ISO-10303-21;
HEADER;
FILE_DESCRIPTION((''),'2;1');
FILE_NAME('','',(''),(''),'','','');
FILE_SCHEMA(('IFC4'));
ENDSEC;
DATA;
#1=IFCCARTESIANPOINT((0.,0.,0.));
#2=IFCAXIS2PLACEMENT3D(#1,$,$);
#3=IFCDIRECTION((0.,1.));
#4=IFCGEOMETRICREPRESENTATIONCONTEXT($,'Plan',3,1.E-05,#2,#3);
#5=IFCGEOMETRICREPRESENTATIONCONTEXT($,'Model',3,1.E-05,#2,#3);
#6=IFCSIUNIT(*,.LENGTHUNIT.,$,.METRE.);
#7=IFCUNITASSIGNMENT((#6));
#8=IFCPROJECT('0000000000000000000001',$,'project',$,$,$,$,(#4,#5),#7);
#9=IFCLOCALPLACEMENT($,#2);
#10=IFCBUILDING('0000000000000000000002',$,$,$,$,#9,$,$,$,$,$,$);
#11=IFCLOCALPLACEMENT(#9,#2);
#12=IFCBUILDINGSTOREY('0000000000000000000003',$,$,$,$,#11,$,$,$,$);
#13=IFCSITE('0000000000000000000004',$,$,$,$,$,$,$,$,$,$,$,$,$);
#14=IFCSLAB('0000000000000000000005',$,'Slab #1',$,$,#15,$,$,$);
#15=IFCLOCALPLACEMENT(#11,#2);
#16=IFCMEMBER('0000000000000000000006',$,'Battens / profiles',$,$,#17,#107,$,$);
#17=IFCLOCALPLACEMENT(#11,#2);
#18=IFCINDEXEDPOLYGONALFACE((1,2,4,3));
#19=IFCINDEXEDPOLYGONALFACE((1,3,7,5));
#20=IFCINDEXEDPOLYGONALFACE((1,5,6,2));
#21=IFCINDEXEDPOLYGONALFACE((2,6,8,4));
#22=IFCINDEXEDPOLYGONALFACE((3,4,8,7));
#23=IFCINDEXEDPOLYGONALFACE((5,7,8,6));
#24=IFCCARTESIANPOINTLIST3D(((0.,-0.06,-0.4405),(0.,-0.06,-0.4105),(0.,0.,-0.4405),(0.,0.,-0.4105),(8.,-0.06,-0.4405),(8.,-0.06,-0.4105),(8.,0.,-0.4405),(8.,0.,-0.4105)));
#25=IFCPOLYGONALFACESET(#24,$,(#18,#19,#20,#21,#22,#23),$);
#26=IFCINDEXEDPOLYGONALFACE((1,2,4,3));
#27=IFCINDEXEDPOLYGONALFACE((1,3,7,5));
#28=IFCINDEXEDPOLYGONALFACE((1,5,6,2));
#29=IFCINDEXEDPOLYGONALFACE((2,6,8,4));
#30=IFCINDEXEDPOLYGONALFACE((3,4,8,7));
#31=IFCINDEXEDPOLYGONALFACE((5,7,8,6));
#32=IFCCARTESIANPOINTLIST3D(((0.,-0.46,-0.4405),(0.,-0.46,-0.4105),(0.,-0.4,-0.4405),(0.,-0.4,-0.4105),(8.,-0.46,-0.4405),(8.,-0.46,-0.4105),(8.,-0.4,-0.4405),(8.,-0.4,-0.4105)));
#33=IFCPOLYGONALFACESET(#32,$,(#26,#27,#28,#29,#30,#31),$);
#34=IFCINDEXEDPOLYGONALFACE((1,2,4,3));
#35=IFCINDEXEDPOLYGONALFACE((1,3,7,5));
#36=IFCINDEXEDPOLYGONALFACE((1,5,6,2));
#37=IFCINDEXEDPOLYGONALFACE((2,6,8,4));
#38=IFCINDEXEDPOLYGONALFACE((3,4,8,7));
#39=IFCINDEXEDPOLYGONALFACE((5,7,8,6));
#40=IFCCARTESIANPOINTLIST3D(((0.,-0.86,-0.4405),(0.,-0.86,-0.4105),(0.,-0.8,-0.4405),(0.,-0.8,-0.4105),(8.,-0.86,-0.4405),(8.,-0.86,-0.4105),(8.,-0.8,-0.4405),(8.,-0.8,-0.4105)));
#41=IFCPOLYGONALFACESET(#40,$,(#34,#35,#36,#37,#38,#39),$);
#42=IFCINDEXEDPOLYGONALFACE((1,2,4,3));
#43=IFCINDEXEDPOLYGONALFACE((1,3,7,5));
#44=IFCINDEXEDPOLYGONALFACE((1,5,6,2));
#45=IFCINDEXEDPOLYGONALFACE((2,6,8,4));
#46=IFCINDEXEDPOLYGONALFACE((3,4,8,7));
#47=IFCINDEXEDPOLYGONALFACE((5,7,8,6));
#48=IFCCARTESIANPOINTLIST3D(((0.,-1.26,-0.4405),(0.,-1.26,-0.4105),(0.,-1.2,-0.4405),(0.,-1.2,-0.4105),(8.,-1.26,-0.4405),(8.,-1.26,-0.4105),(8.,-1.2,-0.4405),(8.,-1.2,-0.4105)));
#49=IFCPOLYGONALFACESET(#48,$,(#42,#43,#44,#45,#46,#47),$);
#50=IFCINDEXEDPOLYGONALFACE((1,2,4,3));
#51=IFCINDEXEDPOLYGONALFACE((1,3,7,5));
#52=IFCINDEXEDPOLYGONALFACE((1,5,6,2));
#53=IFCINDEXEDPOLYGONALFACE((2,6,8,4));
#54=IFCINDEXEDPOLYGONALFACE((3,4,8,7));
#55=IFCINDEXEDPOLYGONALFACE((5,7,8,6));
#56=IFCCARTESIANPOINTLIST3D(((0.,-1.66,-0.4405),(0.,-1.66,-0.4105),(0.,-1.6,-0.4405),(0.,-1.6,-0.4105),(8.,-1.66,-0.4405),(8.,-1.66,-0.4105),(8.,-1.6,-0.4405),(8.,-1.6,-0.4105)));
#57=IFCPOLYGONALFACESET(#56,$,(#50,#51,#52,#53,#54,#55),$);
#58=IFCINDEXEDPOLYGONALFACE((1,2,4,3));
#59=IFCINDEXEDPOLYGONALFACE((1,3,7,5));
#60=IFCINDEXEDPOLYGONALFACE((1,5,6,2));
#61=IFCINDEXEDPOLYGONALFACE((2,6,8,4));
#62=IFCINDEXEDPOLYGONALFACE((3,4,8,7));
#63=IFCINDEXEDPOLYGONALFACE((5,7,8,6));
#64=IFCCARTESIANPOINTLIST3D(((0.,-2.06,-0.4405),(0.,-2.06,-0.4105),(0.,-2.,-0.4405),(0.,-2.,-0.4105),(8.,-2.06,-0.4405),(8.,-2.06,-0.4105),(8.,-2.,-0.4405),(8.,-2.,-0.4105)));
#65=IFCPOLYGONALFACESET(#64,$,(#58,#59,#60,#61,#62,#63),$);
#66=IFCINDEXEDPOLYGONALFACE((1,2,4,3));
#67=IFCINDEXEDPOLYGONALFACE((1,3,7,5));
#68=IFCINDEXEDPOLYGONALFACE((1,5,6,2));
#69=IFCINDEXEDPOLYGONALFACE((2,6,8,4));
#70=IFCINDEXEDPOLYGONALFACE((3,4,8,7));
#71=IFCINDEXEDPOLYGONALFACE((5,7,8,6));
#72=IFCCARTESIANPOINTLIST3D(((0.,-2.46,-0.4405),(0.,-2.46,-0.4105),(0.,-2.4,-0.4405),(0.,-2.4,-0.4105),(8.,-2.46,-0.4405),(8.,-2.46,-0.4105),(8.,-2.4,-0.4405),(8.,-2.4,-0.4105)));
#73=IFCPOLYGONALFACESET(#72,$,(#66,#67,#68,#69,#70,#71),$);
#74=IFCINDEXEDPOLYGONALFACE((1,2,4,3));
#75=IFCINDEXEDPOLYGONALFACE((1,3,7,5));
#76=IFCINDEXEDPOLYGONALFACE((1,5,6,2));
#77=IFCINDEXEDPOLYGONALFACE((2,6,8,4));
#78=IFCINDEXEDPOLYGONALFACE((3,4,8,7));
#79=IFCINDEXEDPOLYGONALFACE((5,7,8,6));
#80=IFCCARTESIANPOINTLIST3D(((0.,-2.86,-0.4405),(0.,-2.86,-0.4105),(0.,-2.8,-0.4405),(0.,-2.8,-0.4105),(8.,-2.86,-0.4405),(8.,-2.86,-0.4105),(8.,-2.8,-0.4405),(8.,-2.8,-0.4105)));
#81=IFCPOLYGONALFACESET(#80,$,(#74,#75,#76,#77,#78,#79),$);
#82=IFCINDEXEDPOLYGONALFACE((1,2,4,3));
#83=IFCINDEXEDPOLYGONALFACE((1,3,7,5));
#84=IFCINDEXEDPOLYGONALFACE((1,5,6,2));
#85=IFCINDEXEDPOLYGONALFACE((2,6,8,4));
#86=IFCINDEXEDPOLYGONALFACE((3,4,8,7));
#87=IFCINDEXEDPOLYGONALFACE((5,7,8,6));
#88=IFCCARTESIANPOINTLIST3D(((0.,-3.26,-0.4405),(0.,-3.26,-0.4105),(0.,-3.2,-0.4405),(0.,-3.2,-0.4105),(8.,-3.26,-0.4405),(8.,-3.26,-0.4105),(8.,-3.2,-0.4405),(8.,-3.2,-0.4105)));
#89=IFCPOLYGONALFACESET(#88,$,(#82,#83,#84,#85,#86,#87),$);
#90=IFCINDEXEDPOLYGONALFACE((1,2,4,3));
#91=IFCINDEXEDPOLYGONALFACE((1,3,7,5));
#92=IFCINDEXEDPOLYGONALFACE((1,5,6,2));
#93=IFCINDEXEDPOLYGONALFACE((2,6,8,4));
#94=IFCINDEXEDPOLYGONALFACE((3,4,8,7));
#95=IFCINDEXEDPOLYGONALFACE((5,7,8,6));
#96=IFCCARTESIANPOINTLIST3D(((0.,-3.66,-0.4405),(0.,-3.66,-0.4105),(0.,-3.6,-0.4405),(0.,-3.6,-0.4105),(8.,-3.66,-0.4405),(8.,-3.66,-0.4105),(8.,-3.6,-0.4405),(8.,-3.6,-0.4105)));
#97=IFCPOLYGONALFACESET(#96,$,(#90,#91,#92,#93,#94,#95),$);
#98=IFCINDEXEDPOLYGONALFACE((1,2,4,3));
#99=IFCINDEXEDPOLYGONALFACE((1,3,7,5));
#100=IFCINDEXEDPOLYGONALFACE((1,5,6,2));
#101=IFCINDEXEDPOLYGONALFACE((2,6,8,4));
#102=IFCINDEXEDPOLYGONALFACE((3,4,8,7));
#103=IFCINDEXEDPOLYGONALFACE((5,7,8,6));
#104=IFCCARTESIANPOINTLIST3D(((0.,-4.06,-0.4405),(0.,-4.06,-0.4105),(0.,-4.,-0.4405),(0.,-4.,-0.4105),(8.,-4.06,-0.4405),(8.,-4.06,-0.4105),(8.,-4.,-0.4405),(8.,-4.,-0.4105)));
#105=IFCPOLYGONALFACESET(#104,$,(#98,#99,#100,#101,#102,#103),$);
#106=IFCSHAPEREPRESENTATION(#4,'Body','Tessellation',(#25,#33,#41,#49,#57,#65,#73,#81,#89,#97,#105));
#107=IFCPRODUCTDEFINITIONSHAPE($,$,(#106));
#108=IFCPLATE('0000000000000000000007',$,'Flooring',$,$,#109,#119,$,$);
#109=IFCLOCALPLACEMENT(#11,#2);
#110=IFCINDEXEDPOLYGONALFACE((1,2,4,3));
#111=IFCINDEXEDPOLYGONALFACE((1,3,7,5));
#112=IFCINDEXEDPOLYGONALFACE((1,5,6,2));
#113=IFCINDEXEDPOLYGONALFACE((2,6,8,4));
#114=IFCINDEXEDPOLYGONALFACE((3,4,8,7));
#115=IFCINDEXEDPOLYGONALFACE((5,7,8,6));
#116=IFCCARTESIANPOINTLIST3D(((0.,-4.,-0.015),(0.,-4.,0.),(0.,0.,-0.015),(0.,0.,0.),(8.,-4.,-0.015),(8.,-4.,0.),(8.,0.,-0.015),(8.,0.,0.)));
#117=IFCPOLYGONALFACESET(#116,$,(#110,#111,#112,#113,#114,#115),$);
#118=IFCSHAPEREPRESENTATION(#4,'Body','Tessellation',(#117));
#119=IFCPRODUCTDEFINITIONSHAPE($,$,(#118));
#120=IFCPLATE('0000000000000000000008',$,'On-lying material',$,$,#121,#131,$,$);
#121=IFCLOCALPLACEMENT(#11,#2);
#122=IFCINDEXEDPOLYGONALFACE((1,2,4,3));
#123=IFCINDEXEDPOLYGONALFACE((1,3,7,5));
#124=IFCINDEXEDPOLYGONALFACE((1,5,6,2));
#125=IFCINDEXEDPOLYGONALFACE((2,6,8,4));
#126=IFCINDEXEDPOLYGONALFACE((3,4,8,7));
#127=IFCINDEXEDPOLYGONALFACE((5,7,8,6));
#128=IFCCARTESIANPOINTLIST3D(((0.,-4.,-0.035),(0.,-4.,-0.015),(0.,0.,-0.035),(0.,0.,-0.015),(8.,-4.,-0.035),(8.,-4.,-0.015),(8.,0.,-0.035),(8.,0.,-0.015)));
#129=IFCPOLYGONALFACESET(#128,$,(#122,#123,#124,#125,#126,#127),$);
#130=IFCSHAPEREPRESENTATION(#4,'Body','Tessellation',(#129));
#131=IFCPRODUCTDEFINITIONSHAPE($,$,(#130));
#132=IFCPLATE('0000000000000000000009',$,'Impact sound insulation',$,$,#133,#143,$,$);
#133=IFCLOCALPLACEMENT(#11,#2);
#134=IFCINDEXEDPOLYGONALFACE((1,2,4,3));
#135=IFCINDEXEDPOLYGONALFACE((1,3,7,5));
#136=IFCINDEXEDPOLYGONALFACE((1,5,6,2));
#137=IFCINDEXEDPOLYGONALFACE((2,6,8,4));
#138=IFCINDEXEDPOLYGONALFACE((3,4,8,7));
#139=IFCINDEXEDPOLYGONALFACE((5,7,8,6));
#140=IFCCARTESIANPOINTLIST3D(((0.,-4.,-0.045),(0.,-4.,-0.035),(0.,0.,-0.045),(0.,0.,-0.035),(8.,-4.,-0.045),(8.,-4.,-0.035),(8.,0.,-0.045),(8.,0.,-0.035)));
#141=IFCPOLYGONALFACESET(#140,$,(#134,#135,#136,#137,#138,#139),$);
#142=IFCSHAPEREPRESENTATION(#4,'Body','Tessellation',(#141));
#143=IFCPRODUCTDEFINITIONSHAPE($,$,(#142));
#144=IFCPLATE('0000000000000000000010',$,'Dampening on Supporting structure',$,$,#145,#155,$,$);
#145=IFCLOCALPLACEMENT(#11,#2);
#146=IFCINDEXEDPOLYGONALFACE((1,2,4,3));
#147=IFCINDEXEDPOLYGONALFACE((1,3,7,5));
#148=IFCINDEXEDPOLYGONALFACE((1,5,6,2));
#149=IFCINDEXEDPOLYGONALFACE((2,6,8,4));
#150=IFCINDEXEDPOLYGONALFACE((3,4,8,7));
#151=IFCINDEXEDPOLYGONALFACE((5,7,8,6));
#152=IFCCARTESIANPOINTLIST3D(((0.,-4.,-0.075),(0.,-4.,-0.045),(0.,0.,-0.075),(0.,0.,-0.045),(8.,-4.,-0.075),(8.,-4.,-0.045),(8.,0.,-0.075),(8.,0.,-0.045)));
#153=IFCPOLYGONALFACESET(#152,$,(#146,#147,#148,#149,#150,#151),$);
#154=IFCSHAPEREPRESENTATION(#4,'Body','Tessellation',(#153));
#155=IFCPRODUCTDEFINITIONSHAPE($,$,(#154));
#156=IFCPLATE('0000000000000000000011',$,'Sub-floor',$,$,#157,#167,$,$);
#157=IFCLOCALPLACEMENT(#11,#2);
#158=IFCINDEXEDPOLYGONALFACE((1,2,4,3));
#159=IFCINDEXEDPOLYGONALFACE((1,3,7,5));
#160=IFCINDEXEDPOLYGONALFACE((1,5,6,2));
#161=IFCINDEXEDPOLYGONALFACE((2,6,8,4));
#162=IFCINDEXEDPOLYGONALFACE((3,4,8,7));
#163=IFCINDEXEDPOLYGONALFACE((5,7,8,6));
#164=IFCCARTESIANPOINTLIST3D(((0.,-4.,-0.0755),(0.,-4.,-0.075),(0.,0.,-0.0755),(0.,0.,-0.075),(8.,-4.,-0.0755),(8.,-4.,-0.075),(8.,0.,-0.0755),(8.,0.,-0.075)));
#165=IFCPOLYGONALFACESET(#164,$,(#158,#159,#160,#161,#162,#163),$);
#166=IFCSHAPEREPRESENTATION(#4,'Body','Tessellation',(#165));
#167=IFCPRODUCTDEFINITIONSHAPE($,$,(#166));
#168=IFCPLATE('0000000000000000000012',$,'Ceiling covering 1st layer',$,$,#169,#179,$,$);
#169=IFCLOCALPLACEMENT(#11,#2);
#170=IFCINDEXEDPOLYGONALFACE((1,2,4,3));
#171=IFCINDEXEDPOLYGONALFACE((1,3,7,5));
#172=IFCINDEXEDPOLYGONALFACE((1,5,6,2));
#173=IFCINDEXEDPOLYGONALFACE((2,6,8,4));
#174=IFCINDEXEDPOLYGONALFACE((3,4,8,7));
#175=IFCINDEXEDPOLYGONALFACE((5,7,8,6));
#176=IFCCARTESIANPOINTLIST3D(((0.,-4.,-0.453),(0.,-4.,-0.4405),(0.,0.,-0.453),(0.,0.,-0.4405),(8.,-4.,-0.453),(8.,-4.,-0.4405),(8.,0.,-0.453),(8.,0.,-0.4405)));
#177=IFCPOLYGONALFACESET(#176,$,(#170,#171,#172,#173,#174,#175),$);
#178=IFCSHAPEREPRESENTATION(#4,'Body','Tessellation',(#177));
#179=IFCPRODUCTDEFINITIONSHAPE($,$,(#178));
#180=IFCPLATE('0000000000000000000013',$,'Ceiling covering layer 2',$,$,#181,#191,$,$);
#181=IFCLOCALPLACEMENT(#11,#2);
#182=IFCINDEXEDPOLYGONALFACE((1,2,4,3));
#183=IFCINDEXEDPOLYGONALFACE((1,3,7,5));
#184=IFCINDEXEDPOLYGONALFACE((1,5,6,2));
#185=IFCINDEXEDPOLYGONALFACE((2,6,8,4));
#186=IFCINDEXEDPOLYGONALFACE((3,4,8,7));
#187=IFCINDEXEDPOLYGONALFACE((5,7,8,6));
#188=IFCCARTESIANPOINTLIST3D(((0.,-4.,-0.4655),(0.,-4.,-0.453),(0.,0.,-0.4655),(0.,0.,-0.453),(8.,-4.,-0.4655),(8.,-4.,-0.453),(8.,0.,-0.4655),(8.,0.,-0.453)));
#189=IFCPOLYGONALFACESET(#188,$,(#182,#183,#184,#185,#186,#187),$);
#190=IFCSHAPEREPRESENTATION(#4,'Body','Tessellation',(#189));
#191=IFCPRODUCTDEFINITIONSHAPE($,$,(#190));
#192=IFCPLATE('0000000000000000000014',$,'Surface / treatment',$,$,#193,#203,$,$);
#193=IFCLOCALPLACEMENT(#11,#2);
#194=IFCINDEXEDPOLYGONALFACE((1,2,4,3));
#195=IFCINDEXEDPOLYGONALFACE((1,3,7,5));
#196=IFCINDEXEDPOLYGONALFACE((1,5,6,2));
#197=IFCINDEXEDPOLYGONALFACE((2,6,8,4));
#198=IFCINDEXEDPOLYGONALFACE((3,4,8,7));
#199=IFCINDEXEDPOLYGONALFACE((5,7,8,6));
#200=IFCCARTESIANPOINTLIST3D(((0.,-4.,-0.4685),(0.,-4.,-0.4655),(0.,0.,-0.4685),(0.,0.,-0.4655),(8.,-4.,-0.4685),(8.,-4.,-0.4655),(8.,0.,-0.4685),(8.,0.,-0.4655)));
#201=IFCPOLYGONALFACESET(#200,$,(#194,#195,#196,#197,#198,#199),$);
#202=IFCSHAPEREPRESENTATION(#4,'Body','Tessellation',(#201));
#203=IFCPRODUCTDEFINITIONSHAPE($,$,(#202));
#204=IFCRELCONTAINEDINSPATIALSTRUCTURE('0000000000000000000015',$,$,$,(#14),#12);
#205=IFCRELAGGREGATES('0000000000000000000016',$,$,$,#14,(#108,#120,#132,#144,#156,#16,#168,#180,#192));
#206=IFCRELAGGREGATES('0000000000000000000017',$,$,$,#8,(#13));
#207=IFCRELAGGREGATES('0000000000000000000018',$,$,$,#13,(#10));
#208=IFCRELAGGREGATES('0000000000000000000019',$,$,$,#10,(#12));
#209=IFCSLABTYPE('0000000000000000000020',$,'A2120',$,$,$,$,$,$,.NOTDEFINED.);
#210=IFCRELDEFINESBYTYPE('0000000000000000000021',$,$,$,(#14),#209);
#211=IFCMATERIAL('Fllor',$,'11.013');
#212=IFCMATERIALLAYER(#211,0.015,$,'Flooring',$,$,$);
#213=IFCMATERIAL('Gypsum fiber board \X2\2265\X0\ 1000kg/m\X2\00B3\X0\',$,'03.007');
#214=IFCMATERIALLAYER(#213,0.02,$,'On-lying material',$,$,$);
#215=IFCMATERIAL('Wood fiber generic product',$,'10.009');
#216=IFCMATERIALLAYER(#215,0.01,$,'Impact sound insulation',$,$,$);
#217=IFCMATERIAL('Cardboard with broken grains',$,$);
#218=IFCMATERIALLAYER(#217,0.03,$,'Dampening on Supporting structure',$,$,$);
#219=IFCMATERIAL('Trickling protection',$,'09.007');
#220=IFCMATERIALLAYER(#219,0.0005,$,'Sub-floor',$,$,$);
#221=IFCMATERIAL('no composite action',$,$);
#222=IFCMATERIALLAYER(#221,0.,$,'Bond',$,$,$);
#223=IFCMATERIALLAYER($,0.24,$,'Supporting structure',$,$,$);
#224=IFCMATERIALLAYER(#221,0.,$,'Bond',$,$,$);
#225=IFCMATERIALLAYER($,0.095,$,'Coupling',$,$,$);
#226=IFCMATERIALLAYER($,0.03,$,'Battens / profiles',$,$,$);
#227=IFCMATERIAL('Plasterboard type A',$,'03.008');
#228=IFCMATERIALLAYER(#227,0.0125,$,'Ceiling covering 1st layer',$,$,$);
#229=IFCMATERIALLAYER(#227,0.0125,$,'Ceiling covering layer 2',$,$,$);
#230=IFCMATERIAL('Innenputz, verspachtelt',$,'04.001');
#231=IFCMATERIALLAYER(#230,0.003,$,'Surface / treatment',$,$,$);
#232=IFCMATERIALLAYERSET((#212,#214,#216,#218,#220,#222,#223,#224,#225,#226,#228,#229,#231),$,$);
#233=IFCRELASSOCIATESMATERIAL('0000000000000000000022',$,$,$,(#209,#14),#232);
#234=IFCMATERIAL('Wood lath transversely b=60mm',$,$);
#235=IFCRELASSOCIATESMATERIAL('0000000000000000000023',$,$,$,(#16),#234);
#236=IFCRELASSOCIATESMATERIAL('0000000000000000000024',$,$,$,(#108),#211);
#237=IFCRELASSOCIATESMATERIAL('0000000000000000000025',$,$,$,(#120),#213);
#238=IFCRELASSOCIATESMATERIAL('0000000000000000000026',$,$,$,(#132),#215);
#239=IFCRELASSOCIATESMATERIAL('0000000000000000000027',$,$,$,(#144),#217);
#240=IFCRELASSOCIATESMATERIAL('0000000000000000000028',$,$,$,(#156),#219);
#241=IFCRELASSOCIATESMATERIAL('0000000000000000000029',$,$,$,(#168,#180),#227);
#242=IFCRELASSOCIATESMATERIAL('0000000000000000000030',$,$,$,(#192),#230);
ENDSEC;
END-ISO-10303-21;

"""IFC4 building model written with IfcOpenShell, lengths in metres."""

from ifc_helpers import new_model, si_unit, direction, frame, frame_2d, origin, origin_with_axes, place, context, project, spatial, rectangle, extrude, material, layer, layer_set, type_object, element, aggregate, save


model = new_model("IFC4")

# Units and contexts
plan_context = context("Plan", 3, precision=1e-05, world=origin(), true_north=direction((0.0, 1.0)))
model_context = context("Model", 3, precision=1e-05, world=origin(), true_north=direction((0.0, 1.0)))
ifc_project = project(units=[si_unit("LENGTHUNIT", "METRE")], contexts=[plan_context, model_context])

# Site, building, storey
site = spatial("IfcSite", under=ifc_project)
building_placement = place(None, origin())
building = spatial("IfcBuilding", under=site, at=building_placement)
storey_placement = place(building_placement, origin())
storey = spatial("IfcBuildingStorey", under=building, at=storey_placement)

# Slab, member, plates
ifc_material_1 = material(Name="Fllor", Category="11.013")
ifc_layer_1 = layer(ifc_material_1, 0.015, Name="Flooring")
ifc_material_2 = material(Name="Gypsum fiber board ≥ 1000kg/m³", Category="03.007")
ifc_layer_2 = layer(ifc_material_2, 0.02, Name="On-lying material")
ifc_material_3 = material(Name="Wood fiber generic product", Category="10.009")
ifc_layer_3 = layer(ifc_material_3, 0.01, Name="Impact sound insulation")
ifc_material_4 = material(Name="Cardboard with broken grains")
ifc_layer_4 = layer(ifc_material_4, 0.03, Name="Dampening on Supporting structure")
ifc_material_5 = material(Name="Trickling protection", Category="09.007")
ifc_layer_5 = layer(ifc_material_5, 0.0005, Name="Sub-floor")
ifc_material_6 = material(Name="no composite action")
ifc_layer_6 = layer(ifc_material_6, 0.0, Name="Bond")
ifc_layer_7 = layer(None, 0.24, Name="Supporting structure")
ifc_layer_8 = layer(ifc_material_6, 0.0, Name="Bond")
ifc_layer_9 = layer(None, 0.095, Name="Coupling")
ifc_layer_10 = layer(None, 0.03, Name="Battens / profiles")
ifc_material_7 = material(Name="Plasterboard type A", Category="03.008")
ifc_layer_11 = layer(ifc_material_7, 0.0125, Name="Ceiling covering 1st layer")
ifc_layer_12 = layer(ifc_material_7, 0.0125, Name="Ceiling covering layer 2")
ifc_material_8 = material(Name="Innenputz, verspachtelt", Category="04.001")
ifc_layer_13 = layer(ifc_material_8, 0.003, Name="Surface / treatment")
ifc_layer_set = layer_set([ifc_layer_1, ifc_layer_2, ifc_layer_3, ifc_layer_4, ifc_layer_5, ifc_layer_6, ifc_layer_7, ifc_layer_8, ifc_layer_9, ifc_layer_10, ifc_layer_11, ifc_layer_12, ifc_layer_13])
slab_type = type_object("IfcSlabType", Name="A2120", PredefinedType="NOTDEFINED", material=ifc_layer_set)
slab_placement = place(None, frame((0.0, 0.0, 0.0), z_axis=(0.0, 0.0, -1.0), x_axis=(1.0, 0.0, 0.0)))
slab = element("IfcSlab", 1, at=slab_placement, inside=storey, type_object=slab_type, material=ifc_layer_set, Name="Slab #1")
ifc_material_9 = material(Name="Wood lath transversely b=60mm")
member_1_placement = place(slab_placement, origin())
member_1 = element("IfcMember", 2, at=member_1_placement, material=ifc_material_9, Name="Battens / profiles", context=plan_context, shape_type="SweptSolid", body=[
    extrude(rectangle(XDim=0.06, YDim=0.03, at=frame_2d((0.03, 0.015), x_axis=(1.0, 0.0))), frame((0.0, 0.0, 0.4105), z_axis=(1.0, 0.0, 0.0), x_axis=(0.0, 1.0, 0.0)), (0.0, 0.0, 1.0), 8.0),
    extrude(rectangle(XDim=0.06, YDim=0.03, at=frame_2d((0.03, 0.015), x_axis=(1.0, 0.0))), frame((0.0, 0.4, 0.4105), z_axis=(1.0, 0.0, 0.0), x_axis=(0.0, 1.0, 0.0)), (0.0, 0.0, 1.0), 8.0),
    extrude(rectangle(XDim=0.06, YDim=0.03, at=frame_2d((0.03, 0.015), x_axis=(1.0, 0.0))), frame((0.0, 0.8, 0.4105), z_axis=(1.0, 0.0, 0.0), x_axis=(0.0, 1.0, 0.0)), (0.0, 0.0, 1.0), 8.0),
    extrude(rectangle(XDim=0.06, YDim=0.03, at=frame_2d((0.03, 0.015), x_axis=(1.0, 0.0))), frame((0.0, 1.2, 0.4105), z_axis=(1.0, 0.0, 0.0), x_axis=(0.0, 1.0, 0.0)), (0.0, 0.0, 1.0), 8.0),
    extrude(rectangle(XDim=0.06, YDim=0.03, at=frame_2d((0.03, 0.015), x_axis=(1.0, 0.0))), frame((0.0, 1.6, 0.4105), z_axis=(1.0, 0.0, 0.0), x_axis=(0.0, 1.0, 0.0)), (0.0, 0.0, 1.0), 8.0),
    extrude(rectangle(XDim=0.06, YDim=0.03, at=frame_2d((0.03, 0.015), x_axis=(1.0, 0.0))), frame((0.0, 2.0, 0.4105), z_axis=(1.0, 0.0, 0.0), x_axis=(0.0, 1.0, 0.0)), (0.0, 0.0, 1.0), 8.0),
    extrude(rectangle(XDim=0.06, YDim=0.03, at=frame_2d((0.03, 0.015), x_axis=(1.0, 0.0))), frame((0.0, 2.4, 0.4105), z_axis=(1.0, 0.0, 0.0), x_axis=(0.0, 1.0, 0.0)), (0.0, 0.0, 1.0), 8.0),
    extrude(rectangle(XDim=0.06, YDim=0.03, at=frame_2d((0.03, 0.015), x_axis=(1.0, 0.0))), frame((0.0, 2.8, 0.4105), z_axis=(1.0, 0.0, 0.0), x_axis=(0.0, 1.0, 0.0)), (0.0, 0.0, 1.0), 8.0),
    extrude(rectangle(XDim=0.06, YDim=0.03, at=frame_2d((0.03, 0.015), x_axis=(1.0, 0.0))), frame((0.0, 3.2, 0.4105), z_axis=(1.0, 0.0, 0.0), x_axis=(0.0, 1.0, 0.0)), (0.0, 0.0, 1.0), 8.0),
    extrude(rectangle(XDim=0.06, YDim=0.03, at=frame_2d((0.03, 0.015), x_axis=(1.0, 0.0))), frame((0.0, 3.6, 0.4105), z_axis=(1.0, 0.0, 0.0), x_axis=(0.0, 1.0, 0.0)), (0.0, 0.0, 1.0), 8.0),
    extrude(rectangle(XDim=0.06, YDim=0.03, at=frame_2d((0.03, 0.015), x_axis=(1.0, 0.0))), frame((0.0, 4.0, 0.4105), z_axis=(1.0, 0.0, 0.0), x_axis=(0.0, 1.0, 0.0)), (0.0, 0.0, 1.0), 8.0),
])
plate_1_placement = place(slab_placement, origin())
plate_1 = element("IfcPlate", 3, at=plate_1_placement, material=ifc_material_1, Name="Flooring", context=plan_context, shape_type="SweptSolid", body=[
    extrude(rectangle(XDim=8.0, YDim=4.0, at=frame_2d((4.0, 2.0), x_axis=(1.0, 0.0))), origin_with_axes(), (0.0, 0.0, 1.0), 0.015),
])
plate_2_placement = place(slab_placement, origin())
plate_2 = element("IfcPlate", 4, at=plate_2_placement, material=ifc_material_2, Name="On-lying material", context=plan_context, shape_type="SweptSolid", body=[
    extrude(rectangle(XDim=8.0, YDim=4.0, at=frame_2d((4.0, 2.0), x_axis=(1.0, 0.0))), frame((0.0, 0.0, 0.015), z_axis=(0.0, 0.0, 1.0), x_axis=(1.0, 0.0, 0.0)), (0.0, 0.0, 1.0), 0.02),
])
plate_3_placement = place(slab_placement, origin())
plate_3 = element("IfcPlate", 5, at=plate_3_placement, material=ifc_material_3, Name="Impact sound insulation", context=plan_context, shape_type="SweptSolid", body=[
    extrude(rectangle(XDim=8.0, YDim=4.0, at=frame_2d((4.0, 2.0), x_axis=(1.0, 0.0))), frame((0.0, 0.0, 0.035), z_axis=(0.0, 0.0, 1.0), x_axis=(1.0, 0.0, 0.0)), (0.0, 0.0, 1.0), 0.01),
])
plate_4_placement = place(slab_placement, origin())
plate_4 = element("IfcPlate", 6, at=plate_4_placement, material=ifc_material_4, Name="Dampening on Supporting structure", context=plan_context, shape_type="SweptSolid", body=[
    extrude(rectangle(XDim=8.0, YDim=4.0, at=frame_2d((4.0, 2.0), x_axis=(1.0, 0.0))), frame((0.0, 0.0, 0.045), z_axis=(0.0, 0.0, 1.0), x_axis=(1.0, 0.0, 0.0)), (0.0, 0.0, 1.0), 0.03),
])
plate_5_placement = place(slab_placement, origin())
plate_5 = element("IfcPlate", 7, at=plate_5_placement, material=ifc_material_5, Name="Sub-floor", context=plan_context, shape_type="SweptSolid", body=[
    extrude(rectangle(XDim=8.0, YDim=4.0, at=frame_2d((4.0, 2.0), x_axis=(1.0, 0.0))), frame((0.0, 0.0, 0.075), z_axis=(0.0, 0.0, 1.0), x_axis=(1.0, 0.0, 0.0)), (0.0, 0.0, 1.0), 0.0005),
])
plate_6_placement = place(slab_placement, origin())
plate_6 = element("IfcPlate", 8, at=plate_6_placement, material=ifc_material_7, Name="Ceiling covering 1st layer", context=plan_context, shape_type="SweptSolid", body=[
    extrude(rectangle(XDim=8.0, YDim=4.0, at=frame_2d((4.0, 2.0), x_axis=(1.0, 0.0))), frame((0.0, 0.0, 0.4405), z_axis=(0.0, 0.0, 1.0), x_axis=(1.0, 0.0, 0.0)), (0.0, 0.0, 1.0), 0.0125),
])
plate_7_placement = place(slab_placement, origin())
plate_7 = element("IfcPlate", 9, at=plate_7_placement, material=ifc_material_7, Name="Ceiling covering layer 2", context=plan_context, shape_type="SweptSolid", body=[
    extrude(rectangle(XDim=8.0, YDim=4.0, at=frame_2d((4.0, 2.0), x_axis=(1.0, 0.0))), frame((0.0, 0.0, 0.453), z_axis=(0.0, 0.0, 1.0), x_axis=(1.0, 0.0, 0.0)), (0.0, 0.0, 1.0), 0.0125),
])
plate_8_placement = place(slab_placement, origin())
plate_8 = element("IfcPlate", 10, at=plate_8_placement, material=ifc_material_8, Name="Surface / treatment", context=plan_context, shape_type="SweptSolid", body=[
    extrude(rectangle(XDim=8.0, YDim=4.0, at=frame_2d((4.0, 2.0), x_axis=(1.0, 0.0))), frame((0.0, 0.0, 0.4655), z_axis=(0.0, 0.0, 1.0), x_axis=(1.0, 0.0, 0.0)), (0.0, 0.0, 1.0), 0.003),
])
aggregate(slab, [plate_1, plate_2, plate_3, plate_4, plate_5, member_1, plate_6, plate_7, plate_8])

save(model, "model.ifc")
